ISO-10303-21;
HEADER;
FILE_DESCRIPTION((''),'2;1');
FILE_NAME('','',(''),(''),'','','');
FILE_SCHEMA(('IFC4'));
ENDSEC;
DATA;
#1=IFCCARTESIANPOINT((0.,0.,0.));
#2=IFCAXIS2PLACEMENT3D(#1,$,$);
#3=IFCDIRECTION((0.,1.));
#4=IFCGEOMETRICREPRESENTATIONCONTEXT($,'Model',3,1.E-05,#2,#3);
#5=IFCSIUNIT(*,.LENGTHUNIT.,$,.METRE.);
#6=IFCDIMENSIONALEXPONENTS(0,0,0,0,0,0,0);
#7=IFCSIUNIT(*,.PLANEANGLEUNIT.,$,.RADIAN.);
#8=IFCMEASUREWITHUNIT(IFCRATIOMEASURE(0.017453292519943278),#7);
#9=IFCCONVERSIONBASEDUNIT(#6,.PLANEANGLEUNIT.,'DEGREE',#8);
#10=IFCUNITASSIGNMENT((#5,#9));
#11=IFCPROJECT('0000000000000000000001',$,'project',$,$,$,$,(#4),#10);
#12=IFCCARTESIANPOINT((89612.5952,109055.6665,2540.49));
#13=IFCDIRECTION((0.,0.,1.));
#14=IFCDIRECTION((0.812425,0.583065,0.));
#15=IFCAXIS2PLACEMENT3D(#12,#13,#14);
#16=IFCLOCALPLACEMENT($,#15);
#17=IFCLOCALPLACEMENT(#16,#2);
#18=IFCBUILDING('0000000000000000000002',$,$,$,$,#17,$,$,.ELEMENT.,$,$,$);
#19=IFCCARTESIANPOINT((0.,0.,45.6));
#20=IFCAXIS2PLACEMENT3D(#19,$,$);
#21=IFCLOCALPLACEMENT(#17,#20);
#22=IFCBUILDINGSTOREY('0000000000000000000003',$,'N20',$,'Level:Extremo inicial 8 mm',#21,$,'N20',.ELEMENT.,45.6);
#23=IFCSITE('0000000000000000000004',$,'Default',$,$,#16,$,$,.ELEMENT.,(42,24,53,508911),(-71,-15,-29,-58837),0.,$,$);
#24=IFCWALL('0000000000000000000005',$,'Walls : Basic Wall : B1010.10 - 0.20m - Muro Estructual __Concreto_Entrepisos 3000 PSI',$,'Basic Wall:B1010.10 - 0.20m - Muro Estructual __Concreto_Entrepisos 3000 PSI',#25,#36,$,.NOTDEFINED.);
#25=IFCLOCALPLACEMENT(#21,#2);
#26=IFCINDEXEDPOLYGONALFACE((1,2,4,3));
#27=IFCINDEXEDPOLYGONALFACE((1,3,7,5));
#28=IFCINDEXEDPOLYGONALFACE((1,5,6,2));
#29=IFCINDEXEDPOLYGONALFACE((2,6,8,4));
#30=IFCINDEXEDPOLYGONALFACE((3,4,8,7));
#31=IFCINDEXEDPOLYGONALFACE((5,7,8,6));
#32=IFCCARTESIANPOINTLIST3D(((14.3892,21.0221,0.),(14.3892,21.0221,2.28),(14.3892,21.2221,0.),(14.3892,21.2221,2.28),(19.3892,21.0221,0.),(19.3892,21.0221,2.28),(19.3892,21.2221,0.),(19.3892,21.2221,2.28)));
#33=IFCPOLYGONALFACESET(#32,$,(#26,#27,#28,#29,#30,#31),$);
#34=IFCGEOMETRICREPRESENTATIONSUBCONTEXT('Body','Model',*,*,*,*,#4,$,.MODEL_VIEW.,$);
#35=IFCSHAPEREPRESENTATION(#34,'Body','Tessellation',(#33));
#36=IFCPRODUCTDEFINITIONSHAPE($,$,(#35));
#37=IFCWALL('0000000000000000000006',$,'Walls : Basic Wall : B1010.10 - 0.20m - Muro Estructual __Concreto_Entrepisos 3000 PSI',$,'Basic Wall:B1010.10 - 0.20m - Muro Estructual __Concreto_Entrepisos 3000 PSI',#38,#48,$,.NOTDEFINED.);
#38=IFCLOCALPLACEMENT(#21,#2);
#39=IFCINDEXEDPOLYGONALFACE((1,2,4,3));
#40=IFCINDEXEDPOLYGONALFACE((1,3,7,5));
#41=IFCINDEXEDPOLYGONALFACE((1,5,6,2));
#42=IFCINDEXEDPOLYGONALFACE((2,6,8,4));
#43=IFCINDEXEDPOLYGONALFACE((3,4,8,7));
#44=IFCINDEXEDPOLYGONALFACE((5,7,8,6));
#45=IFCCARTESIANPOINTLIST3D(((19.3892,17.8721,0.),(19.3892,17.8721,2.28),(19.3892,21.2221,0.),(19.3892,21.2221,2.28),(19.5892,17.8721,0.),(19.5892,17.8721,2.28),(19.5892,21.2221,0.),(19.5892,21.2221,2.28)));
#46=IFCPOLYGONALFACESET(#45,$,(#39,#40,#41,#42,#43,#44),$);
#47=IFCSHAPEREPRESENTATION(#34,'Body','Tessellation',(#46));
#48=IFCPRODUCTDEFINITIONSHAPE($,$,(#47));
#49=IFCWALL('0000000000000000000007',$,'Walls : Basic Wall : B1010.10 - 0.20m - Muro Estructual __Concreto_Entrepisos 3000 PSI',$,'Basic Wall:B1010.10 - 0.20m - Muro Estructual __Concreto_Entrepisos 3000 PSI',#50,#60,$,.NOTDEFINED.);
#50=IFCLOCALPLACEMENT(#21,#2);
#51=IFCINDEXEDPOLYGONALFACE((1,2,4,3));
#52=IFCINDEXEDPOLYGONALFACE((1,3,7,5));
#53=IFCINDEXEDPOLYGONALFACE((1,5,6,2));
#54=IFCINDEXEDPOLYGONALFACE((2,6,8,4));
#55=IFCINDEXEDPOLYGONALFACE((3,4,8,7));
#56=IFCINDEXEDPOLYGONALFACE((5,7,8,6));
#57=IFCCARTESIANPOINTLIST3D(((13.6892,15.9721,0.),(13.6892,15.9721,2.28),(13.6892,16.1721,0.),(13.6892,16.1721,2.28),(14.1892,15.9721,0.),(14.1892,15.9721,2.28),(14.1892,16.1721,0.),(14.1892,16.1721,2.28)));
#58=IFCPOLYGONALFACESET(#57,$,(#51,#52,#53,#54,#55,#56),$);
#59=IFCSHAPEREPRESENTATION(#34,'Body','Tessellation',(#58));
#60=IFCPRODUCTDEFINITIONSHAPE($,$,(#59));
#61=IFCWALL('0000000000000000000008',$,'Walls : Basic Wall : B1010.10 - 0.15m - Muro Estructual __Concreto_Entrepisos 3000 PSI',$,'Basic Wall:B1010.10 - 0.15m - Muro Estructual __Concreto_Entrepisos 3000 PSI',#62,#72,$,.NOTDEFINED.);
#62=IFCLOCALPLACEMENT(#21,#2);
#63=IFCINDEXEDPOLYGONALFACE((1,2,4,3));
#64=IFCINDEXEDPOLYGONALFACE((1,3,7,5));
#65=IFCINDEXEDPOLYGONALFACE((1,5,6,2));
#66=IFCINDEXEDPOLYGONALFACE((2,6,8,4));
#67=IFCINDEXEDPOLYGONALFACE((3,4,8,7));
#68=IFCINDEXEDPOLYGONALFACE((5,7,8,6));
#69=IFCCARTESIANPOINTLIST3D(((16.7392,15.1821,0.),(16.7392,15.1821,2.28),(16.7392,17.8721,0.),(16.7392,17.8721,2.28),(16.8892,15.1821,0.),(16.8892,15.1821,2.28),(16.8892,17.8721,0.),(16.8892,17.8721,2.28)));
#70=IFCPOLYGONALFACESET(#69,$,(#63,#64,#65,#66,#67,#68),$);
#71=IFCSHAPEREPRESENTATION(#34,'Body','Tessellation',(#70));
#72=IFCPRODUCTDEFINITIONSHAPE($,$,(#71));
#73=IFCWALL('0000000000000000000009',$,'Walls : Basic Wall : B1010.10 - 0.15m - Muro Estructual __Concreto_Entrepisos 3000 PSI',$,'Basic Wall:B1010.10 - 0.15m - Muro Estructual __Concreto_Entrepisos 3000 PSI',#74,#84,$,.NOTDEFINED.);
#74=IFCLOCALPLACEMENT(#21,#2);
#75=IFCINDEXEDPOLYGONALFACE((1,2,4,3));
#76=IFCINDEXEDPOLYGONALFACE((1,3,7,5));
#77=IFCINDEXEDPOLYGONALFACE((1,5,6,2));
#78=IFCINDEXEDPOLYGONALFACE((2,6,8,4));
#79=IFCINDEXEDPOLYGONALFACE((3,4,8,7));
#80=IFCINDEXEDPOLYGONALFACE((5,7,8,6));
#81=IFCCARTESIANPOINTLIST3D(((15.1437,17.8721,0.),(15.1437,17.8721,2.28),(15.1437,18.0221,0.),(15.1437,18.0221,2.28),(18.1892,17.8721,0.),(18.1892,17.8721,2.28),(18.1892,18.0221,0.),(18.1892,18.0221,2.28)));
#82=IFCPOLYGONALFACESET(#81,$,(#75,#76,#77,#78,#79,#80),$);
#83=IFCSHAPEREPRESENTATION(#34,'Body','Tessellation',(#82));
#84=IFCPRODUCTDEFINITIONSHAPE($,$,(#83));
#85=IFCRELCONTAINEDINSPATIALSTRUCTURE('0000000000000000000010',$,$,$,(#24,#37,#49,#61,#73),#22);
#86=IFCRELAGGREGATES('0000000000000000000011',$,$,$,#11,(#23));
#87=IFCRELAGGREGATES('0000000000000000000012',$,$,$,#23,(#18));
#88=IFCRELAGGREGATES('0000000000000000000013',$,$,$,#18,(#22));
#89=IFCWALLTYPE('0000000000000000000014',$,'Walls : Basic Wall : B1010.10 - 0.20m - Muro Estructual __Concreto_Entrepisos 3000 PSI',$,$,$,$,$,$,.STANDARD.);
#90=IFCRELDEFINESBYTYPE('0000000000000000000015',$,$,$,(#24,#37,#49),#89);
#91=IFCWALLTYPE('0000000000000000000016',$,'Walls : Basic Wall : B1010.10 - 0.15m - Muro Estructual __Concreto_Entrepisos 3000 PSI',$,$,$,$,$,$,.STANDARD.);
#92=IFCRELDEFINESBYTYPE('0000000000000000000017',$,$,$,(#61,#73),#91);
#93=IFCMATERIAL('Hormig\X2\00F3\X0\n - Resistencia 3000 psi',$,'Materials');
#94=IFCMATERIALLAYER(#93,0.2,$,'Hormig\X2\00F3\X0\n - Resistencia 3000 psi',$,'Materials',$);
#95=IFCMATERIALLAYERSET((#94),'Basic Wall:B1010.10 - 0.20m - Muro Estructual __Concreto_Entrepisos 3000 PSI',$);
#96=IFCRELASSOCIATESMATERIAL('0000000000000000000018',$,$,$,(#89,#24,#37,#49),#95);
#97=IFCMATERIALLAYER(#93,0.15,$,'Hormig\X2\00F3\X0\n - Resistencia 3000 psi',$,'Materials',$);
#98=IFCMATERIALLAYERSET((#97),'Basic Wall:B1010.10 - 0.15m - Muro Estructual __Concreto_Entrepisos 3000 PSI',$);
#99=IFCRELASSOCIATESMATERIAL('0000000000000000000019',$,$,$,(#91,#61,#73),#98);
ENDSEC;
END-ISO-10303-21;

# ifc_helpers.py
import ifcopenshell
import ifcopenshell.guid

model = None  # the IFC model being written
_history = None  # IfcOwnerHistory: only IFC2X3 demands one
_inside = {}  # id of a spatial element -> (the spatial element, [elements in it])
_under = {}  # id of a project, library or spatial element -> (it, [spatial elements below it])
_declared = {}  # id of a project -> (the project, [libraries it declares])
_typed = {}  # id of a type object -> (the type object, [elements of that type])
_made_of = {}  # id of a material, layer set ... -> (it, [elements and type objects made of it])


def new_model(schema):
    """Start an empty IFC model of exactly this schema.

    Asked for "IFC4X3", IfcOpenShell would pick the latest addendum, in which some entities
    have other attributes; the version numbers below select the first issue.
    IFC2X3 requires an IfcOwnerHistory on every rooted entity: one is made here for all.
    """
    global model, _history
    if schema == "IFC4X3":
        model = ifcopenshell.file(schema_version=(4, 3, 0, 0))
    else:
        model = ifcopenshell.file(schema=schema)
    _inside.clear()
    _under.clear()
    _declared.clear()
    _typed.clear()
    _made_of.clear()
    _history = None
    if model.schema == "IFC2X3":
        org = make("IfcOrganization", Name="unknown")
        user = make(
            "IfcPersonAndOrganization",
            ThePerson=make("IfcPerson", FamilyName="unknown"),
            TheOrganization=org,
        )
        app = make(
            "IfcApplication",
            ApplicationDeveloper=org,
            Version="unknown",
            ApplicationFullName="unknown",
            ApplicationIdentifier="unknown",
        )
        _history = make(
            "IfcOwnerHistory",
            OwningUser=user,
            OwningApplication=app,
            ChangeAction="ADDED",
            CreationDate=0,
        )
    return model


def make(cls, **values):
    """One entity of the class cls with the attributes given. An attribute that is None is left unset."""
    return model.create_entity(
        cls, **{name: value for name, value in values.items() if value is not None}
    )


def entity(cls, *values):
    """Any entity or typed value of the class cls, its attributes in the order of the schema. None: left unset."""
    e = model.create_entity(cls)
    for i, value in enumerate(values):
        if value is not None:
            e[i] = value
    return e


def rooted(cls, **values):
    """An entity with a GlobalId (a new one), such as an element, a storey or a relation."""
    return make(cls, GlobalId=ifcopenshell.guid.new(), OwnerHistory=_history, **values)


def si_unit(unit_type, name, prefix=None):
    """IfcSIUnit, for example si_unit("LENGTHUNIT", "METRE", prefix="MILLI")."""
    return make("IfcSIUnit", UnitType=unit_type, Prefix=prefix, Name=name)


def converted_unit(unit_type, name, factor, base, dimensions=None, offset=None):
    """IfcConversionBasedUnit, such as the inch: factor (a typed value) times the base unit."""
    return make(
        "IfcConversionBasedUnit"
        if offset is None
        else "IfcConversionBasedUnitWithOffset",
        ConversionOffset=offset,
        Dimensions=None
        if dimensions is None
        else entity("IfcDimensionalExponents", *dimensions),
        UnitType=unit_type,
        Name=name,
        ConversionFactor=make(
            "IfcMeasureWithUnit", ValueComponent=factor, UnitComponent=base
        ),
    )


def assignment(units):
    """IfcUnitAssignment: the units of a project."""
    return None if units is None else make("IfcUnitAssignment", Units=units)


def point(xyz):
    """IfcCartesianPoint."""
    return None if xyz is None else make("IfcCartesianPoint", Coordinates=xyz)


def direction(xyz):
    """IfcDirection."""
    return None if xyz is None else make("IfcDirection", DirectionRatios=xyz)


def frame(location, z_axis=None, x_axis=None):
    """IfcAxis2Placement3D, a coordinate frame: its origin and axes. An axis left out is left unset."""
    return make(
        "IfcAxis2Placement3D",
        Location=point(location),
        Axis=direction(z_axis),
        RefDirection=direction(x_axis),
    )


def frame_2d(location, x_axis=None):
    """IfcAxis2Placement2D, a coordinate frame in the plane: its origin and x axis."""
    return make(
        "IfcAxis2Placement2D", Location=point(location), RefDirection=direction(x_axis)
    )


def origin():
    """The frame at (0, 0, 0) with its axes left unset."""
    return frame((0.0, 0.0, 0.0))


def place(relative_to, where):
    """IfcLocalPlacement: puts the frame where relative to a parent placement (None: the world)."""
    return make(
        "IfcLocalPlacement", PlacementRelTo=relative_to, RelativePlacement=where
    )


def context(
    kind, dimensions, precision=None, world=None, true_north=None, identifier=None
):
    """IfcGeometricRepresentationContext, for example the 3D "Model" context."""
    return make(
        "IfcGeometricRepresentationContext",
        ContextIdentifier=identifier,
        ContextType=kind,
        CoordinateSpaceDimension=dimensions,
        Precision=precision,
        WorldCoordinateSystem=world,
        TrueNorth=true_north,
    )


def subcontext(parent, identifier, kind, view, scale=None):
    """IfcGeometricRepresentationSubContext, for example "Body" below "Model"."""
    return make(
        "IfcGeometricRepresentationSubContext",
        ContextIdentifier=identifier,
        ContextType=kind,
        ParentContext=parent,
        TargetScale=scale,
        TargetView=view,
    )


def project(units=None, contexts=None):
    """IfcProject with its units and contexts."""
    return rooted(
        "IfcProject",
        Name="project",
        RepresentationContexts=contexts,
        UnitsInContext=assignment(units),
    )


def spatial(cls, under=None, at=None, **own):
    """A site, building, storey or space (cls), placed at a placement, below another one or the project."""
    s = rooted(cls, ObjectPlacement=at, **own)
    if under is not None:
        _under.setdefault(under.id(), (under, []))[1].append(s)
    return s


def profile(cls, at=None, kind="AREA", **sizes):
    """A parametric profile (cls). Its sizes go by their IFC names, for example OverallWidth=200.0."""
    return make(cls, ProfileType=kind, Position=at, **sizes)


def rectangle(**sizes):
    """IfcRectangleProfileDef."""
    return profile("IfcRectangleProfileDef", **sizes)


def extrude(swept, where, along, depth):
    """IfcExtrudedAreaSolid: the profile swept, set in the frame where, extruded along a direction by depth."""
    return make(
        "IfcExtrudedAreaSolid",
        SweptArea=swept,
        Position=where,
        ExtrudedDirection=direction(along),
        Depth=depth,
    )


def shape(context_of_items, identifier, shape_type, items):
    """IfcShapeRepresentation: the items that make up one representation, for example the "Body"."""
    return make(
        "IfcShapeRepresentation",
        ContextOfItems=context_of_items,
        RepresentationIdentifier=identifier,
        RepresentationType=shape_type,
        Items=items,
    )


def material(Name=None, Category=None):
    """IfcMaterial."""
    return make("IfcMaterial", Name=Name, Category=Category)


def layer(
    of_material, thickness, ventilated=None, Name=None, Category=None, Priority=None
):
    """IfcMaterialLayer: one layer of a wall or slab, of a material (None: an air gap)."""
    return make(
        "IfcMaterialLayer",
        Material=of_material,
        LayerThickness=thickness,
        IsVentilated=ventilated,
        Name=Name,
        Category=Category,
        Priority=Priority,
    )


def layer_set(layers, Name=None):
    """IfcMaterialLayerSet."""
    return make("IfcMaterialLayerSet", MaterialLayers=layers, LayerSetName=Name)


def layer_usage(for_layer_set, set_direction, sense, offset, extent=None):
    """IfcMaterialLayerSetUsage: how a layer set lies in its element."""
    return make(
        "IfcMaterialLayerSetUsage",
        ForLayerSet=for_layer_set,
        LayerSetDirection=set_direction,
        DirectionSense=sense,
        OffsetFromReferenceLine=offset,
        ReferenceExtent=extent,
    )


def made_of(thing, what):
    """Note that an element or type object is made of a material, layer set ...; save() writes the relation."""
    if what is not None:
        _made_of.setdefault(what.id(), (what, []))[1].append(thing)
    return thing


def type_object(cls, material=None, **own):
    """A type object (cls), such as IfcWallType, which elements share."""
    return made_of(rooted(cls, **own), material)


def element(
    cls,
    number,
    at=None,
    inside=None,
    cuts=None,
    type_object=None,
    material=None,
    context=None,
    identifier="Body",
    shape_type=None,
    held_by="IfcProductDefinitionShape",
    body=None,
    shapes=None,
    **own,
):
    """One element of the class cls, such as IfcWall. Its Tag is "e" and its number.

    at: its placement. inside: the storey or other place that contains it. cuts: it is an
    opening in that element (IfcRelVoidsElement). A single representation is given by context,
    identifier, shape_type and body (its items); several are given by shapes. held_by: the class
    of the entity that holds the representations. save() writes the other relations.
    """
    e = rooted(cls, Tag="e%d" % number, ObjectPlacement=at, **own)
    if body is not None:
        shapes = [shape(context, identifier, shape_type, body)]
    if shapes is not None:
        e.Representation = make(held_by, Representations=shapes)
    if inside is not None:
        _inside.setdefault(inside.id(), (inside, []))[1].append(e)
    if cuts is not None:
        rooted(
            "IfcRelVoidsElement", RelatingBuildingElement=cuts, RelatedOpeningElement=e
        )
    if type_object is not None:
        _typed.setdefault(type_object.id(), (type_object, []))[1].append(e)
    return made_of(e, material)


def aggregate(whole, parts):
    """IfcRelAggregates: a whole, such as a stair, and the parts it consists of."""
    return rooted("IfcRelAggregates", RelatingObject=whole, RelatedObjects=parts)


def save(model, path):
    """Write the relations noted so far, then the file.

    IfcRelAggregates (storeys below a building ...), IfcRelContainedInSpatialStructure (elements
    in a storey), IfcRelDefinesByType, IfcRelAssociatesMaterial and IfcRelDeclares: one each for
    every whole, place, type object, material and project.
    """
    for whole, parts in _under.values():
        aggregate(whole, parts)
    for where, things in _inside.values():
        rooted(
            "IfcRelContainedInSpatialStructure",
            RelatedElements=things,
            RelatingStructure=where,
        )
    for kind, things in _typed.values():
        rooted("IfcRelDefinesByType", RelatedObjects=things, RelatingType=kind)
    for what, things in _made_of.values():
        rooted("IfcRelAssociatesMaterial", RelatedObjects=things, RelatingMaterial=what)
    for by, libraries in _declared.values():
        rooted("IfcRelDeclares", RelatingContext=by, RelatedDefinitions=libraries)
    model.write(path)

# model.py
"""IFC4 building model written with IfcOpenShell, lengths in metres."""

from ifc_helpers import new_model, entity, si_unit, converted_unit, direction, frame, frame_2d, origin, place, context, subcontext, project, spatial, rectangle, extrude, material, layer, layer_set, layer_usage, type_object, element, save


model = new_model("IFC4")

# Units and contexts
model_context = context("Model", 3, precision=1e-05, world=origin(), true_north=direction((0.0, 1.0)))
body_context = subcontext(model_context, "Body", "Model", "MODEL_VIEW")
ifc_project = project(units=[si_unit("LENGTHUNIT", "METRE"), converted_unit("PLANEANGLEUNIT", "DEGREE", entity("IfcRatioMeasure", 0.017453292519943278), si_unit("PLANEANGLEUNIT", "RADIAN"), dimensions=[0, 0, 0, 0, 0, 0, 0])], contexts=[model_context])

# Site, building, storey
site_placement = place(None, frame((89612.5952, 109055.6665, 2540.49), z_axis=(0.0, 0.0, 1.0), x_axis=(0.812425, 0.583065, 0.0)))
site = spatial("IfcSite", under=ifc_project, at=site_placement, Name="Default", CompositionType="ELEMENT", RefLatitude=(42, 24, 53, 508911), RefLongitude=(-71, -15, -29, -58837), RefElevation=0.0)
building_placement = place(site_placement, origin())
building = spatial("IfcBuilding", under=site, at=building_placement, CompositionType="ELEMENT")
storey_placement = place(building_placement, frame((0.0, 0.0, 45.6)))
storey = spatial("IfcBuildingStorey", under=building, at=storey_placement, Name="N20", ObjectType="Level:Extremo inicial 8 mm", LongName="N20", CompositionType="ELEMENT", Elevation=45.6)

# Walls
ifc_material_1 = material(Name="Hormigón - Resistencia 3000 psi", Category="Materials")
ifc_layer_1 = layer(ifc_material_1, 0.2, Name="Hormigón - Resistencia 3000 psi", Category="Materials")
ifc_layer_set_1 = layer_set([ifc_layer_1], Name="Basic Wall:B1010.10 - 0.20m - Muro Estructual __Concreto_Entrepisos 3000 PSI")
wall_type_1 = type_object("IfcWallType", Name="Walls : Basic Wall : B1010.10 - 0.20m - Muro Estructual __Concreto_Entrepisos 3000 PSI", PredefinedType="STANDARD", material=ifc_layer_set_1)
ifc_layer_usage_1 = layer_usage(ifc_layer_set_1, "AXIS2", "NEGATIVE", 0.1)
wall_1_placement = place(storey_placement, frame((14.3892, 21.1221, 0.0)))
element("IfcWall", 1, at=wall_1_placement, inside=storey, type_object=wall_type_1, material=ifc_layer_usage_1, Name="Walls : Basic Wall : B1010.10 - 0.20m - Muro Estructual __Concreto_Entrepisos 3000 PSI", ObjectType="Basic Wall:B1010.10 - 0.20m - Muro Estructual __Concreto_Entrepisos 3000 PSI", PredefinedType="NOTDEFINED", context=body_context, shape_type="SweptSolid", body=[
    extrude(rectangle(XDim=5.0, YDim=0.2, at=frame_2d((2.5, 0.0), x_axis=(-1.0, 0.0))), origin(), (0.0, 0.0, 1.0), 2.28),
])
ifc_layer_usage_2 = layer_usage(ifc_layer_set_1, "AXIS2", "NEGATIVE", 0.1)
wall_2_placement = place(storey_placement, frame((19.4892, 21.2221, 0.0), z_axis=(0.0, 0.0, 1.0), x_axis=(0.0, -1.0, 0.0)))
element("IfcWall", 2, at=wall_2_placement, inside=storey, type_object=wall_type_1, material=ifc_layer_usage_2, Name="Walls : Basic Wall : B1010.10 - 0.20m - Muro Estructual __Concreto_Entrepisos 3000 PSI", ObjectType="Basic Wall:B1010.10 - 0.20m - Muro Estructual __Concreto_Entrepisos 3000 PSI", PredefinedType="NOTDEFINED", context=body_context, shape_type="SweptSolid", body=[
    extrude(rectangle(XDim=3.35, YDim=0.2, at=frame_2d((1.675, 0.0), x_axis=(-1.0, 0.0))), origin(), (0.0, 0.0, 1.0), 2.28),
])
ifc_layer_usage_3 = layer_usage(ifc_layer_set_1, "AXIS2", "NEGATIVE", 0.1)
wall_3_placement = place(storey_placement, frame((13.6892, 16.0721, 0.0)))
element("IfcWall", 3, at=wall_3_placement, inside=storey, type_object=wall_type_1, material=ifc_layer_usage_3, Name="Walls : Basic Wall : B1010.10 - 0.20m - Muro Estructual __Concreto_Entrepisos 3000 PSI", ObjectType="Basic Wall:B1010.10 - 0.20m - Muro Estructual __Concreto_Entrepisos 3000 PSI", PredefinedType="NOTDEFINED", context=body_context, shape_type="SweptSolid", body=[
    extrude(rectangle(XDim=0.5, YDim=0.2, at=frame_2d((0.25, 0.0), x_axis=(-1.0, 0.0))), origin(), (0.0, 0.0, 1.0), 2.28),
])
ifc_layer_2 = layer(ifc_material_1, 0.15, Name="Hormigón - Resistencia 3000 psi", Category="Materials")
ifc_layer_set_2 = layer_set([ifc_layer_2], Name="Basic Wall:B1010.10 - 0.15m - Muro Estructual __Concreto_Entrepisos 3000 PSI")
ifc_layer_usage_4 = layer_usage(ifc_layer_set_2, "AXIS2", "NEGATIVE", 0.075)
wall_type_2 = type_object("IfcWallType", Name="Walls : Basic Wall : B1010.10 - 0.15m - Muro Estructual __Concreto_Entrepisos 3000 PSI", PredefinedType="STANDARD", material=ifc_layer_set_2)
wall_4_placement = place(storey_placement, frame((16.8142, 15.1821, 0.0), z_axis=(0.0, 0.0, 1.0), x_axis=(0.0, 1.0, 0.0)))
element("IfcWall", 4, at=wall_4_placement, inside=storey, type_object=wall_type_2, material=ifc_layer_usage_4, Name="Walls : Basic Wall : B1010.10 - 0.15m - Muro Estructual __Concreto_Entrepisos 3000 PSI", ObjectType="Basic Wall:B1010.10 - 0.15m - Muro Estructual __Concreto_Entrepisos 3000 PSI", PredefinedType="NOTDEFINED", context=body_context, shape_type="SweptSolid", body=[
    extrude(rectangle(XDim=2.69, YDim=0.15, at=frame_2d((1.345, 0.0), x_axis=(-1.0, 0.0))), origin(), (0.0, 0.0, 1.0), 2.28),
])
ifc_layer_usage_5 = layer_usage(ifc_layer_set_2, "AXIS2", "NEGATIVE", 0.075)
wall_5_placement = place(storey_placement, frame((18.1892, 17.9471, 0.0), z_axis=(0.0, 0.0, 1.0), x_axis=(-1.0, 0.0, 0.0)))
element("IfcWall", 5, at=wall_5_placement, inside=storey, type_object=wall_type_2, material=ifc_layer_usage_5, Name="Walls : Basic Wall : B1010.10 - 0.15m - Muro Estructual __Concreto_Entrepisos 3000 PSI", ObjectType="Basic Wall:B1010.10 - 0.15m - Muro Estructual __Concreto_Entrepisos 3000 PSI", PredefinedType="NOTDEFINED", context=body_context, shape_type="SweptSolid", body=[
    extrude(rectangle(XDim=3.0455, YDim=0.15, at=frame_2d((1.5228, 0.0), x_axis=(-1.0, 0.0))), origin(), (0.0, 0.0, 1.0), 2.28),
])

save(model, "model.ifc")
